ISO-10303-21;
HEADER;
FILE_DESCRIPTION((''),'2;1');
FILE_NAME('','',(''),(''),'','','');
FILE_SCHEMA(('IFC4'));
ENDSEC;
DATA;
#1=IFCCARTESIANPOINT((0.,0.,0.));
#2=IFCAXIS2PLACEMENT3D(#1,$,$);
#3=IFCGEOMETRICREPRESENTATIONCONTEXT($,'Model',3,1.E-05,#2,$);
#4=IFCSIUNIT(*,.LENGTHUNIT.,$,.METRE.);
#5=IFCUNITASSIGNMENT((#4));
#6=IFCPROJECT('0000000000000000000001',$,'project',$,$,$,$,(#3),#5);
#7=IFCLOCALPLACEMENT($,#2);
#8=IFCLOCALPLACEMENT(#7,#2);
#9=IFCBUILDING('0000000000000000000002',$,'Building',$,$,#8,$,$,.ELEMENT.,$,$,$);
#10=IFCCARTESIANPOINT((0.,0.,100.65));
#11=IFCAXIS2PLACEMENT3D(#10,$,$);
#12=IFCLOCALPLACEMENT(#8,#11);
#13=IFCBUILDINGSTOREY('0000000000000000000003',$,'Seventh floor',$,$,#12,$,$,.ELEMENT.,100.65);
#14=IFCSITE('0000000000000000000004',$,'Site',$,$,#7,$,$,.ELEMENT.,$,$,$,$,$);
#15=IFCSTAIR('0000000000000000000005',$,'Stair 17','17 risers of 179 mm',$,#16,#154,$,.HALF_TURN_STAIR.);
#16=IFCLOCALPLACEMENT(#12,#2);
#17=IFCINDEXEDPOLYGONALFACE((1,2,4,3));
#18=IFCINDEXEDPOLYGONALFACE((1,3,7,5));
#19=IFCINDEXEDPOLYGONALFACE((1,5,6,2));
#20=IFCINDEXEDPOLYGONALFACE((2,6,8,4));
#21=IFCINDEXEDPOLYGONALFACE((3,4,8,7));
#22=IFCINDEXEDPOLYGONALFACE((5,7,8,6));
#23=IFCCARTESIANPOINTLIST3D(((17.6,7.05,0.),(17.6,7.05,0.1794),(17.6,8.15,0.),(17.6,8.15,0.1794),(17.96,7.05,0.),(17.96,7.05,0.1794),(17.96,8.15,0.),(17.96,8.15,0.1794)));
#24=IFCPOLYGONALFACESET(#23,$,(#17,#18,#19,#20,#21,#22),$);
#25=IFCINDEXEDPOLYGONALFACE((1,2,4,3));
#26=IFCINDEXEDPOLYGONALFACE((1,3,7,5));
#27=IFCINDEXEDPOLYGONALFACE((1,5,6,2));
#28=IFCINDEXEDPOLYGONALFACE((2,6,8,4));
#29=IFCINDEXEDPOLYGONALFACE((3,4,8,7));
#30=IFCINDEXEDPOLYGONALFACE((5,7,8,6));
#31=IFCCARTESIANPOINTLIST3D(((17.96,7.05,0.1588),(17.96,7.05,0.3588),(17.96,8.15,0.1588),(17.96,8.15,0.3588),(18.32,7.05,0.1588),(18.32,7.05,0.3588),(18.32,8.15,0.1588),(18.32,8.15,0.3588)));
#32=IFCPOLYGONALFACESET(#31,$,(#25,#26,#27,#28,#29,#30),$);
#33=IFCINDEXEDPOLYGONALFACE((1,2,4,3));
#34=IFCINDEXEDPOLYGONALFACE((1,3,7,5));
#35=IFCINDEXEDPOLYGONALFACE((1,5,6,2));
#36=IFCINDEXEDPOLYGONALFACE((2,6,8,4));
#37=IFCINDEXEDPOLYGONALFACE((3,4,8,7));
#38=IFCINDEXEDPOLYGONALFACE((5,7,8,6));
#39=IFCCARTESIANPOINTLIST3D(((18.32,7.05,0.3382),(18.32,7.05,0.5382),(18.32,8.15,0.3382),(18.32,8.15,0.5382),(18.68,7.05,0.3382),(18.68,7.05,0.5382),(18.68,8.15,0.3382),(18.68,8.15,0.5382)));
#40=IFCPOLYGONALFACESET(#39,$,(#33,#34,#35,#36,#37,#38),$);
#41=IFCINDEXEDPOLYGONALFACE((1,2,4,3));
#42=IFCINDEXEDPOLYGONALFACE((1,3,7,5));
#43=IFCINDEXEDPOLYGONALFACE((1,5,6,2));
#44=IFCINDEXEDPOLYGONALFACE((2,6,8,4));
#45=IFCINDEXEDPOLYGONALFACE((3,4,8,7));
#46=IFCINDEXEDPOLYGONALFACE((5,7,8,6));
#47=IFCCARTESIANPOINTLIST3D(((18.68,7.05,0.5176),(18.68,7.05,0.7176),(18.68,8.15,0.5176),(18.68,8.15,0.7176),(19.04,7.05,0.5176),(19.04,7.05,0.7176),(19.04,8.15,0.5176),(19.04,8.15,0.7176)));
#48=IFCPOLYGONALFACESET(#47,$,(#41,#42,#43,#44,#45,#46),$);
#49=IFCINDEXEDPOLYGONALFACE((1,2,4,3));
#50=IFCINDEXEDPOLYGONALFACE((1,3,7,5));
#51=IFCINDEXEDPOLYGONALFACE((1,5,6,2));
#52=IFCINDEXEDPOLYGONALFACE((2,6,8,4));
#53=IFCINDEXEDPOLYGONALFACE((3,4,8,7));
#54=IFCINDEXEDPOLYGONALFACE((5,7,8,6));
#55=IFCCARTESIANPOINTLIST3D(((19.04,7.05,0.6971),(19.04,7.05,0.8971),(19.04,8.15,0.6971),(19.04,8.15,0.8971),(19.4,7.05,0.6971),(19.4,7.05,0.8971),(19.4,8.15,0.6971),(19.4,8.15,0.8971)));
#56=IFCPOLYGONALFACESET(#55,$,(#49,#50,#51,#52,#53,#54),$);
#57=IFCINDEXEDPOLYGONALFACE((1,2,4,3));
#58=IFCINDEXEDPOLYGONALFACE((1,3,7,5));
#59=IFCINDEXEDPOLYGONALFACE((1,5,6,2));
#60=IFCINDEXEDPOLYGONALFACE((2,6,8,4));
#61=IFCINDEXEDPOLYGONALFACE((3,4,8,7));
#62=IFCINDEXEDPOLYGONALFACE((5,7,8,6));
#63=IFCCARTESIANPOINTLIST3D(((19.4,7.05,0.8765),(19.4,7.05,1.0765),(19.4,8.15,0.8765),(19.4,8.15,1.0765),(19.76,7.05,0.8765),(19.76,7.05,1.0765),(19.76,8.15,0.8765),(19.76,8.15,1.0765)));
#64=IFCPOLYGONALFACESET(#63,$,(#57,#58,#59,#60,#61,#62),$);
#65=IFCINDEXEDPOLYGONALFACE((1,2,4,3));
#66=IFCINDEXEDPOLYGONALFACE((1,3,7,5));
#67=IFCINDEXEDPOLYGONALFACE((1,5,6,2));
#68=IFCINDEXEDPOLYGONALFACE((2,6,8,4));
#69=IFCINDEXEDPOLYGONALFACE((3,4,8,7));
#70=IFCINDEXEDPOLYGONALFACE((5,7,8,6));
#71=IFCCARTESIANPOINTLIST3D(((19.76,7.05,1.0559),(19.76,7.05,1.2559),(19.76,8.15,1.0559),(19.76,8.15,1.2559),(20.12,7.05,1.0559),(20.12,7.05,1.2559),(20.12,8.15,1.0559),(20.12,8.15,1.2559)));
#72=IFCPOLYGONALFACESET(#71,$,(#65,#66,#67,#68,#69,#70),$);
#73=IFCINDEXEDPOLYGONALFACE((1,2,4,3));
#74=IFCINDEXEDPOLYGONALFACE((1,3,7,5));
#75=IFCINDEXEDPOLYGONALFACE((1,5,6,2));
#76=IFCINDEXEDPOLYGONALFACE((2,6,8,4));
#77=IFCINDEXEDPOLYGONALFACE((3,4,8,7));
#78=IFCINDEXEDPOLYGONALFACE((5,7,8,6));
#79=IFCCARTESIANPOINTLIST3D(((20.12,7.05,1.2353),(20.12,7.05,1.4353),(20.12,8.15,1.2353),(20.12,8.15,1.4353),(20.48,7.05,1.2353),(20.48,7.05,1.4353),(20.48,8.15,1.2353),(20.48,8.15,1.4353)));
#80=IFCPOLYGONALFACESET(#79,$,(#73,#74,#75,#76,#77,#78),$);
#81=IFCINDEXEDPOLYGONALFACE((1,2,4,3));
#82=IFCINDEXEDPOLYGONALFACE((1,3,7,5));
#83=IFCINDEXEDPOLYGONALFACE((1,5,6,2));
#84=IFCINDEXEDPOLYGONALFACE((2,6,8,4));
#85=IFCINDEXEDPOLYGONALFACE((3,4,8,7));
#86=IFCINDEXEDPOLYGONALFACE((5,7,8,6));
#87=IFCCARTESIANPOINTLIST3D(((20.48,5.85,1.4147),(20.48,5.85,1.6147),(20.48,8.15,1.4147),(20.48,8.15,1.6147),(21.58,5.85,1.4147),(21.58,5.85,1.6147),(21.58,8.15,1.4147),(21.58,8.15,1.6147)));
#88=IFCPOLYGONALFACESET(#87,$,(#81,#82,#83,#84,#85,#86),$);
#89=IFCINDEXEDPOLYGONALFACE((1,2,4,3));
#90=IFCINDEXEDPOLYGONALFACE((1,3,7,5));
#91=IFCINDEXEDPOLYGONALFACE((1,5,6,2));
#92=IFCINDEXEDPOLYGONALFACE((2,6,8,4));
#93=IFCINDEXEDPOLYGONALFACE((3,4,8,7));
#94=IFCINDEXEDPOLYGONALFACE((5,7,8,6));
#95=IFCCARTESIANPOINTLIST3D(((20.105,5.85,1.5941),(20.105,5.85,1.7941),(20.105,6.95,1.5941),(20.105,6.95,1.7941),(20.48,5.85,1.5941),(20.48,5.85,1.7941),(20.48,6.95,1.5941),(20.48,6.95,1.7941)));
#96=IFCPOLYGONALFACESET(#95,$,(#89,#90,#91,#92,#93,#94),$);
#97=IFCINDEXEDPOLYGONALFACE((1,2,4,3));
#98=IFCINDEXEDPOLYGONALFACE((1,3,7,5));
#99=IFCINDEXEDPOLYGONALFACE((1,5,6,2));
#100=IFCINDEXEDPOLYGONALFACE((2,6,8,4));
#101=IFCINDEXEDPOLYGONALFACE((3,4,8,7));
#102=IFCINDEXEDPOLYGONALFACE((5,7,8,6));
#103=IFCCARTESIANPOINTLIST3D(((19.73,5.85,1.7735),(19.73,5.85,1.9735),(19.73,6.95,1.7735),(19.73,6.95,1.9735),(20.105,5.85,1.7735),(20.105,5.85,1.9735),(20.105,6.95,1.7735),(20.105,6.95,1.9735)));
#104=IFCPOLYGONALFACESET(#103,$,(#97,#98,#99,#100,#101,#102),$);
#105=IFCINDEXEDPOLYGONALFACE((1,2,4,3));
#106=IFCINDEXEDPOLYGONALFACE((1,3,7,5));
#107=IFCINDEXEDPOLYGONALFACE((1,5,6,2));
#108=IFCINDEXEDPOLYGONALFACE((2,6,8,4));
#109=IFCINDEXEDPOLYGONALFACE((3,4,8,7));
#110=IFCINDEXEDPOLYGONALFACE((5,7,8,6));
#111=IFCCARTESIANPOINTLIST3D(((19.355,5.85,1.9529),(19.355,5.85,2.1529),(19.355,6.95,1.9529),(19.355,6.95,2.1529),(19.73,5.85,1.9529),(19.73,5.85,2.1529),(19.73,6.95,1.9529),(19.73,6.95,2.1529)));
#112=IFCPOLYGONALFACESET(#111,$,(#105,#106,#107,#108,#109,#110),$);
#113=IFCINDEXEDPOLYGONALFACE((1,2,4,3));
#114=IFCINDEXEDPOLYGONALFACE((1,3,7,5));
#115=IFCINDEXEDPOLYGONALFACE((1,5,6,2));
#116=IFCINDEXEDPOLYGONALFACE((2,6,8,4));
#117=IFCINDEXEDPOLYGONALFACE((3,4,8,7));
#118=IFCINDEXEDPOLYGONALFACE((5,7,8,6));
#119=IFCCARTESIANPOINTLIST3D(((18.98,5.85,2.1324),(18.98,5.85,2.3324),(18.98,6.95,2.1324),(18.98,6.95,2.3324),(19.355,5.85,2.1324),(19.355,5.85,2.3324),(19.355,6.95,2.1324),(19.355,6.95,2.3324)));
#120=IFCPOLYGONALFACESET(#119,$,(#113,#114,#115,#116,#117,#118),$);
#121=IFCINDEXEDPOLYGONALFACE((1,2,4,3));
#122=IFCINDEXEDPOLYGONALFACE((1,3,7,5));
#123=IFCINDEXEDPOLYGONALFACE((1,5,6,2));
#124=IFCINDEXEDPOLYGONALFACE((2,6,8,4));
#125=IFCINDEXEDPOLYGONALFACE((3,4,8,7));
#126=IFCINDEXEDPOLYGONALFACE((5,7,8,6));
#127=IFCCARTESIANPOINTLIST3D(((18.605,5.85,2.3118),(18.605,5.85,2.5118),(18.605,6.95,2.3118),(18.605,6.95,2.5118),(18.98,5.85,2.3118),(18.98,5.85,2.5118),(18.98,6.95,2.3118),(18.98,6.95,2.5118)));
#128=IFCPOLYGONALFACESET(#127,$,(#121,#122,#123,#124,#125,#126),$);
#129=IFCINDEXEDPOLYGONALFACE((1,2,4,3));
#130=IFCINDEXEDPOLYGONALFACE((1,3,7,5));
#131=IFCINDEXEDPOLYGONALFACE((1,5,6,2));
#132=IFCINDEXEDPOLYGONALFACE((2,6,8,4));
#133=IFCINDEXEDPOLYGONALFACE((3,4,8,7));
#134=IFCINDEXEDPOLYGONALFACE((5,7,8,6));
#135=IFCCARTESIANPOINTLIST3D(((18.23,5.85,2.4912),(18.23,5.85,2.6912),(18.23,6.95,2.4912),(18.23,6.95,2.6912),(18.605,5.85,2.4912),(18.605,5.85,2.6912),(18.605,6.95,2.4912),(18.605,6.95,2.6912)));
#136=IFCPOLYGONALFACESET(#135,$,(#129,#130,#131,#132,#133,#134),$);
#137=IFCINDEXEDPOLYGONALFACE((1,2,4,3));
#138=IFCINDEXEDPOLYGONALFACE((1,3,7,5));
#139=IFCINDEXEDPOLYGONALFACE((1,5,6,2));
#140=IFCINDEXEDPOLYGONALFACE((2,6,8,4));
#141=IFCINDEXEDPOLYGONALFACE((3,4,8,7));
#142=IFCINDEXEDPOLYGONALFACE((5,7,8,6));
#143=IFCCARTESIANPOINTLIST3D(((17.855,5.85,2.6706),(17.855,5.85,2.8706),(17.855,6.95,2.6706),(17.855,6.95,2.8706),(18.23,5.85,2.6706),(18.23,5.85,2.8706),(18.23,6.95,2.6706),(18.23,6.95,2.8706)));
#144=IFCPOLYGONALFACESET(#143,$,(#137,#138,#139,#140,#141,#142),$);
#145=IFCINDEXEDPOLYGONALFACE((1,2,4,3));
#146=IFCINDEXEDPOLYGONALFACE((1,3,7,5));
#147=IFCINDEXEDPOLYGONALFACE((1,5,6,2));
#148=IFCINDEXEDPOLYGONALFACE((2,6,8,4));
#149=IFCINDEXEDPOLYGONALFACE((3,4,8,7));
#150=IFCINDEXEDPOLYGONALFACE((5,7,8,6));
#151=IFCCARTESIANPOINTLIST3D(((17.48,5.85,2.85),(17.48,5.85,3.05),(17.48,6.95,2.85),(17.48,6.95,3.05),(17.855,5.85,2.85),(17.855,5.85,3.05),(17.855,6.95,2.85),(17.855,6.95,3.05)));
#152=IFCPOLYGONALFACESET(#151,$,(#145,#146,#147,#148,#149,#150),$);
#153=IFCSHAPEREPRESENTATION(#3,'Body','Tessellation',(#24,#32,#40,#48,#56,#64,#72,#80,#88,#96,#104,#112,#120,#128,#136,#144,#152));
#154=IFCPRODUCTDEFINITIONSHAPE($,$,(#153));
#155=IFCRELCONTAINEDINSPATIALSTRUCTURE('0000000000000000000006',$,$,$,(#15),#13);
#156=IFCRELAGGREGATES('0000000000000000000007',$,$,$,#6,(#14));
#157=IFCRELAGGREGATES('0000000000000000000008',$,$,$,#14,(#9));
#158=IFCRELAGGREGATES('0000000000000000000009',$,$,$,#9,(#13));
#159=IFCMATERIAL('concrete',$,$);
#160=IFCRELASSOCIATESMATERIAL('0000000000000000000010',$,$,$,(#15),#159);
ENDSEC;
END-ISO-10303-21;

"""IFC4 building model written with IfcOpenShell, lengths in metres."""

from ifc_helpers import new_model, si_unit, frame, origin, place, context, project, spatial, polyline, outline, extrude, material, element, save


model = new_model("IFC4")

# Units and contexts
model_context = context("Model", 3, precision=1e-05, world=origin())
ifc_project = project(units=[si_unit("LENGTHUNIT", "METRE")], contexts=[model_context])

# Site, building, storey
site_placement = place(None, origin())
site = spatial("IfcSite", under=ifc_project, at=site_placement, Name="Site", CompositionType="ELEMENT")
building_placement = place(site_placement, origin())
building = spatial("IfcBuilding", under=site, at=building_placement, Name="Building", CompositionType="ELEMENT")
storey_placement = place(building_placement, frame((0.0, 0.0, 100.65)))
storey = spatial("IfcBuildingStorey", under=building, at=storey_placement, Name="Seventh floor", CompositionType="ELEMENT", Elevation=100.65)

# Shared definitions
ifc_material = material(Name="concrete")

# Stair
stair_1_placement = place(storey_placement, frame((17.6, 7.6, 0.0), z_axis=(0.0, 0.0, 1.0), x_axis=(1.0, 0.0, 0.0)))
element("IfcStair", 1, at=stair_1_placement, inside=storey, material=ifc_material, Name="Stair 17", Description="17 risers of 179 mm", PredefinedType="HALF_TURN_STAIR", context=model_context, shape_type="SweptSolid", body=[
    extrude(outline(polyline([(0.0, -0.55), (0.36, -0.55), (0.36, 0.55), (0.0, 0.55), (0.0, -0.55)])), origin(), (0.0, 0.0, 1.0), 0.1794),
    extrude(outline(polyline([(0.36, -0.55), (0.72, -0.55), (0.72, 0.55), (0.36, 0.55), (0.36, -0.55)])), frame((0.0, 0.0, 0.1588)), (0.0, 0.0, 1.0), 0.2),
    extrude(outline(polyline([(0.72, -0.55), (1.08, -0.55), (1.08, 0.55), (0.72, 0.55), (0.72, -0.55)])), frame((0.0, 0.0, 0.3382)), (0.0, 0.0, 1.0), 0.2),
    extrude(outline(polyline([(1.08, -0.55), (1.44, -0.55), (1.44, 0.55), (1.08, 0.55), (1.08, -0.55)])), frame((0.0, 0.0, 0.5176)), (0.0, 0.0, 1.0), 0.2),
    extrude(outline(polyline([(1.44, -0.55), (1.8, -0.55), (1.8, 0.55), (1.44, 0.55), (1.44, -0.55)])), frame((0.0, 0.0, 0.6971)), (0.0, 0.0, 1.0), 0.2),
    extrude(outline(polyline([(1.8, -0.55), (2.16, -0.55), (2.16, 0.55), (1.8, 0.55), (1.8, -0.55)])), frame((0.0, 0.0, 0.8765)), (0.0, 0.0, 1.0), 0.2),
    extrude(outline(polyline([(2.16, -0.55), (2.52, -0.55), (2.52, 0.55), (2.16, 0.55), (2.16, -0.55)])), frame((0.0, 0.0, 1.0559)), (0.0, 0.0, 1.0), 0.2),
    extrude(outline(polyline([(2.52, -0.55), (2.88, -0.55), (2.88, 0.55), (2.52, 0.55), (2.52, -0.55)])), frame((0.0, 0.0, 1.2353)), (0.0, 0.0, 1.0), 0.2),
    extrude(outline(polyline([(2.88, -1.75), (3.98, -1.75), (3.98, 0.55), (2.88, 0.55), (2.88, -1.75)])), frame((0.0, 0.0, 1.4147)), (0.0, 0.0, 1.0), 0.2),
    extrude(outline(polyline([(2.505, -1.75), (2.88, -1.75), (2.88, -0.65), (2.505, -0.65), (2.505, -1.75)])), frame((0.0, 0.0, 1.5941)), (0.0, 0.0, 1.0), 0.2),
    extrude(outline(polyline([(2.13, -1.75), (2.505, -1.75), (2.505, -0.65), (2.13, -0.65), (2.13, -1.75)])), frame((0.0, 0.0, 1.7735)), (0.0, 0.0, 1.0), 0.2),
    extrude(outline(polyline([(1.755, -1.75), (2.13, -1.75), (2.13, -0.65), (1.755, -0.65), (1.755, -1.75)])), frame((0.0, 0.0, 1.9529)), (0.0, 0.0, 1.0), 0.2),
    extrude(outline(polyline([(1.38, -1.75), (1.755, -1.75), (1.755, -0.65), (1.38, -0.65), (1.38, -1.75)])), frame((0.0, 0.0, 2.1324)), (0.0, 0.0, 1.0), 0.2),
    extrude(outline(polyline([(1.005, -1.75), (1.38, -1.75), (1.38, -0.65), (1.005, -0.65), (1.005, -1.75)])), frame((0.0, 0.0, 2.3118)), (0.0, 0.0, 1.0), 0.2),
    extrude(outline(polyline([(0.63, -1.75), (1.005, -1.75), (1.005, -0.65), (0.63, -0.65), (0.63, -1.75)])), frame((0.0, 0.0, 2.4912)), (0.0, 0.0, 1.0), 0.2),
    extrude(outline(polyline([(0.255, -1.75), (0.63, -1.75), (0.63, -0.65), (0.255, -0.65), (0.255, -1.75)])), frame((0.0, 0.0, 2.6706)), (0.0, 0.0, 1.0), 0.2),
    extrude(outline(polyline([(-0.12, -1.75), (0.255, -1.75), (0.255, -0.65), (-0.12, -0.65), (-0.12, -1.75)])), frame((0.0, 0.0, 2.85)), (0.0, 0.0, 1.0), 0.2),
])

save(model, "model.ifc")
